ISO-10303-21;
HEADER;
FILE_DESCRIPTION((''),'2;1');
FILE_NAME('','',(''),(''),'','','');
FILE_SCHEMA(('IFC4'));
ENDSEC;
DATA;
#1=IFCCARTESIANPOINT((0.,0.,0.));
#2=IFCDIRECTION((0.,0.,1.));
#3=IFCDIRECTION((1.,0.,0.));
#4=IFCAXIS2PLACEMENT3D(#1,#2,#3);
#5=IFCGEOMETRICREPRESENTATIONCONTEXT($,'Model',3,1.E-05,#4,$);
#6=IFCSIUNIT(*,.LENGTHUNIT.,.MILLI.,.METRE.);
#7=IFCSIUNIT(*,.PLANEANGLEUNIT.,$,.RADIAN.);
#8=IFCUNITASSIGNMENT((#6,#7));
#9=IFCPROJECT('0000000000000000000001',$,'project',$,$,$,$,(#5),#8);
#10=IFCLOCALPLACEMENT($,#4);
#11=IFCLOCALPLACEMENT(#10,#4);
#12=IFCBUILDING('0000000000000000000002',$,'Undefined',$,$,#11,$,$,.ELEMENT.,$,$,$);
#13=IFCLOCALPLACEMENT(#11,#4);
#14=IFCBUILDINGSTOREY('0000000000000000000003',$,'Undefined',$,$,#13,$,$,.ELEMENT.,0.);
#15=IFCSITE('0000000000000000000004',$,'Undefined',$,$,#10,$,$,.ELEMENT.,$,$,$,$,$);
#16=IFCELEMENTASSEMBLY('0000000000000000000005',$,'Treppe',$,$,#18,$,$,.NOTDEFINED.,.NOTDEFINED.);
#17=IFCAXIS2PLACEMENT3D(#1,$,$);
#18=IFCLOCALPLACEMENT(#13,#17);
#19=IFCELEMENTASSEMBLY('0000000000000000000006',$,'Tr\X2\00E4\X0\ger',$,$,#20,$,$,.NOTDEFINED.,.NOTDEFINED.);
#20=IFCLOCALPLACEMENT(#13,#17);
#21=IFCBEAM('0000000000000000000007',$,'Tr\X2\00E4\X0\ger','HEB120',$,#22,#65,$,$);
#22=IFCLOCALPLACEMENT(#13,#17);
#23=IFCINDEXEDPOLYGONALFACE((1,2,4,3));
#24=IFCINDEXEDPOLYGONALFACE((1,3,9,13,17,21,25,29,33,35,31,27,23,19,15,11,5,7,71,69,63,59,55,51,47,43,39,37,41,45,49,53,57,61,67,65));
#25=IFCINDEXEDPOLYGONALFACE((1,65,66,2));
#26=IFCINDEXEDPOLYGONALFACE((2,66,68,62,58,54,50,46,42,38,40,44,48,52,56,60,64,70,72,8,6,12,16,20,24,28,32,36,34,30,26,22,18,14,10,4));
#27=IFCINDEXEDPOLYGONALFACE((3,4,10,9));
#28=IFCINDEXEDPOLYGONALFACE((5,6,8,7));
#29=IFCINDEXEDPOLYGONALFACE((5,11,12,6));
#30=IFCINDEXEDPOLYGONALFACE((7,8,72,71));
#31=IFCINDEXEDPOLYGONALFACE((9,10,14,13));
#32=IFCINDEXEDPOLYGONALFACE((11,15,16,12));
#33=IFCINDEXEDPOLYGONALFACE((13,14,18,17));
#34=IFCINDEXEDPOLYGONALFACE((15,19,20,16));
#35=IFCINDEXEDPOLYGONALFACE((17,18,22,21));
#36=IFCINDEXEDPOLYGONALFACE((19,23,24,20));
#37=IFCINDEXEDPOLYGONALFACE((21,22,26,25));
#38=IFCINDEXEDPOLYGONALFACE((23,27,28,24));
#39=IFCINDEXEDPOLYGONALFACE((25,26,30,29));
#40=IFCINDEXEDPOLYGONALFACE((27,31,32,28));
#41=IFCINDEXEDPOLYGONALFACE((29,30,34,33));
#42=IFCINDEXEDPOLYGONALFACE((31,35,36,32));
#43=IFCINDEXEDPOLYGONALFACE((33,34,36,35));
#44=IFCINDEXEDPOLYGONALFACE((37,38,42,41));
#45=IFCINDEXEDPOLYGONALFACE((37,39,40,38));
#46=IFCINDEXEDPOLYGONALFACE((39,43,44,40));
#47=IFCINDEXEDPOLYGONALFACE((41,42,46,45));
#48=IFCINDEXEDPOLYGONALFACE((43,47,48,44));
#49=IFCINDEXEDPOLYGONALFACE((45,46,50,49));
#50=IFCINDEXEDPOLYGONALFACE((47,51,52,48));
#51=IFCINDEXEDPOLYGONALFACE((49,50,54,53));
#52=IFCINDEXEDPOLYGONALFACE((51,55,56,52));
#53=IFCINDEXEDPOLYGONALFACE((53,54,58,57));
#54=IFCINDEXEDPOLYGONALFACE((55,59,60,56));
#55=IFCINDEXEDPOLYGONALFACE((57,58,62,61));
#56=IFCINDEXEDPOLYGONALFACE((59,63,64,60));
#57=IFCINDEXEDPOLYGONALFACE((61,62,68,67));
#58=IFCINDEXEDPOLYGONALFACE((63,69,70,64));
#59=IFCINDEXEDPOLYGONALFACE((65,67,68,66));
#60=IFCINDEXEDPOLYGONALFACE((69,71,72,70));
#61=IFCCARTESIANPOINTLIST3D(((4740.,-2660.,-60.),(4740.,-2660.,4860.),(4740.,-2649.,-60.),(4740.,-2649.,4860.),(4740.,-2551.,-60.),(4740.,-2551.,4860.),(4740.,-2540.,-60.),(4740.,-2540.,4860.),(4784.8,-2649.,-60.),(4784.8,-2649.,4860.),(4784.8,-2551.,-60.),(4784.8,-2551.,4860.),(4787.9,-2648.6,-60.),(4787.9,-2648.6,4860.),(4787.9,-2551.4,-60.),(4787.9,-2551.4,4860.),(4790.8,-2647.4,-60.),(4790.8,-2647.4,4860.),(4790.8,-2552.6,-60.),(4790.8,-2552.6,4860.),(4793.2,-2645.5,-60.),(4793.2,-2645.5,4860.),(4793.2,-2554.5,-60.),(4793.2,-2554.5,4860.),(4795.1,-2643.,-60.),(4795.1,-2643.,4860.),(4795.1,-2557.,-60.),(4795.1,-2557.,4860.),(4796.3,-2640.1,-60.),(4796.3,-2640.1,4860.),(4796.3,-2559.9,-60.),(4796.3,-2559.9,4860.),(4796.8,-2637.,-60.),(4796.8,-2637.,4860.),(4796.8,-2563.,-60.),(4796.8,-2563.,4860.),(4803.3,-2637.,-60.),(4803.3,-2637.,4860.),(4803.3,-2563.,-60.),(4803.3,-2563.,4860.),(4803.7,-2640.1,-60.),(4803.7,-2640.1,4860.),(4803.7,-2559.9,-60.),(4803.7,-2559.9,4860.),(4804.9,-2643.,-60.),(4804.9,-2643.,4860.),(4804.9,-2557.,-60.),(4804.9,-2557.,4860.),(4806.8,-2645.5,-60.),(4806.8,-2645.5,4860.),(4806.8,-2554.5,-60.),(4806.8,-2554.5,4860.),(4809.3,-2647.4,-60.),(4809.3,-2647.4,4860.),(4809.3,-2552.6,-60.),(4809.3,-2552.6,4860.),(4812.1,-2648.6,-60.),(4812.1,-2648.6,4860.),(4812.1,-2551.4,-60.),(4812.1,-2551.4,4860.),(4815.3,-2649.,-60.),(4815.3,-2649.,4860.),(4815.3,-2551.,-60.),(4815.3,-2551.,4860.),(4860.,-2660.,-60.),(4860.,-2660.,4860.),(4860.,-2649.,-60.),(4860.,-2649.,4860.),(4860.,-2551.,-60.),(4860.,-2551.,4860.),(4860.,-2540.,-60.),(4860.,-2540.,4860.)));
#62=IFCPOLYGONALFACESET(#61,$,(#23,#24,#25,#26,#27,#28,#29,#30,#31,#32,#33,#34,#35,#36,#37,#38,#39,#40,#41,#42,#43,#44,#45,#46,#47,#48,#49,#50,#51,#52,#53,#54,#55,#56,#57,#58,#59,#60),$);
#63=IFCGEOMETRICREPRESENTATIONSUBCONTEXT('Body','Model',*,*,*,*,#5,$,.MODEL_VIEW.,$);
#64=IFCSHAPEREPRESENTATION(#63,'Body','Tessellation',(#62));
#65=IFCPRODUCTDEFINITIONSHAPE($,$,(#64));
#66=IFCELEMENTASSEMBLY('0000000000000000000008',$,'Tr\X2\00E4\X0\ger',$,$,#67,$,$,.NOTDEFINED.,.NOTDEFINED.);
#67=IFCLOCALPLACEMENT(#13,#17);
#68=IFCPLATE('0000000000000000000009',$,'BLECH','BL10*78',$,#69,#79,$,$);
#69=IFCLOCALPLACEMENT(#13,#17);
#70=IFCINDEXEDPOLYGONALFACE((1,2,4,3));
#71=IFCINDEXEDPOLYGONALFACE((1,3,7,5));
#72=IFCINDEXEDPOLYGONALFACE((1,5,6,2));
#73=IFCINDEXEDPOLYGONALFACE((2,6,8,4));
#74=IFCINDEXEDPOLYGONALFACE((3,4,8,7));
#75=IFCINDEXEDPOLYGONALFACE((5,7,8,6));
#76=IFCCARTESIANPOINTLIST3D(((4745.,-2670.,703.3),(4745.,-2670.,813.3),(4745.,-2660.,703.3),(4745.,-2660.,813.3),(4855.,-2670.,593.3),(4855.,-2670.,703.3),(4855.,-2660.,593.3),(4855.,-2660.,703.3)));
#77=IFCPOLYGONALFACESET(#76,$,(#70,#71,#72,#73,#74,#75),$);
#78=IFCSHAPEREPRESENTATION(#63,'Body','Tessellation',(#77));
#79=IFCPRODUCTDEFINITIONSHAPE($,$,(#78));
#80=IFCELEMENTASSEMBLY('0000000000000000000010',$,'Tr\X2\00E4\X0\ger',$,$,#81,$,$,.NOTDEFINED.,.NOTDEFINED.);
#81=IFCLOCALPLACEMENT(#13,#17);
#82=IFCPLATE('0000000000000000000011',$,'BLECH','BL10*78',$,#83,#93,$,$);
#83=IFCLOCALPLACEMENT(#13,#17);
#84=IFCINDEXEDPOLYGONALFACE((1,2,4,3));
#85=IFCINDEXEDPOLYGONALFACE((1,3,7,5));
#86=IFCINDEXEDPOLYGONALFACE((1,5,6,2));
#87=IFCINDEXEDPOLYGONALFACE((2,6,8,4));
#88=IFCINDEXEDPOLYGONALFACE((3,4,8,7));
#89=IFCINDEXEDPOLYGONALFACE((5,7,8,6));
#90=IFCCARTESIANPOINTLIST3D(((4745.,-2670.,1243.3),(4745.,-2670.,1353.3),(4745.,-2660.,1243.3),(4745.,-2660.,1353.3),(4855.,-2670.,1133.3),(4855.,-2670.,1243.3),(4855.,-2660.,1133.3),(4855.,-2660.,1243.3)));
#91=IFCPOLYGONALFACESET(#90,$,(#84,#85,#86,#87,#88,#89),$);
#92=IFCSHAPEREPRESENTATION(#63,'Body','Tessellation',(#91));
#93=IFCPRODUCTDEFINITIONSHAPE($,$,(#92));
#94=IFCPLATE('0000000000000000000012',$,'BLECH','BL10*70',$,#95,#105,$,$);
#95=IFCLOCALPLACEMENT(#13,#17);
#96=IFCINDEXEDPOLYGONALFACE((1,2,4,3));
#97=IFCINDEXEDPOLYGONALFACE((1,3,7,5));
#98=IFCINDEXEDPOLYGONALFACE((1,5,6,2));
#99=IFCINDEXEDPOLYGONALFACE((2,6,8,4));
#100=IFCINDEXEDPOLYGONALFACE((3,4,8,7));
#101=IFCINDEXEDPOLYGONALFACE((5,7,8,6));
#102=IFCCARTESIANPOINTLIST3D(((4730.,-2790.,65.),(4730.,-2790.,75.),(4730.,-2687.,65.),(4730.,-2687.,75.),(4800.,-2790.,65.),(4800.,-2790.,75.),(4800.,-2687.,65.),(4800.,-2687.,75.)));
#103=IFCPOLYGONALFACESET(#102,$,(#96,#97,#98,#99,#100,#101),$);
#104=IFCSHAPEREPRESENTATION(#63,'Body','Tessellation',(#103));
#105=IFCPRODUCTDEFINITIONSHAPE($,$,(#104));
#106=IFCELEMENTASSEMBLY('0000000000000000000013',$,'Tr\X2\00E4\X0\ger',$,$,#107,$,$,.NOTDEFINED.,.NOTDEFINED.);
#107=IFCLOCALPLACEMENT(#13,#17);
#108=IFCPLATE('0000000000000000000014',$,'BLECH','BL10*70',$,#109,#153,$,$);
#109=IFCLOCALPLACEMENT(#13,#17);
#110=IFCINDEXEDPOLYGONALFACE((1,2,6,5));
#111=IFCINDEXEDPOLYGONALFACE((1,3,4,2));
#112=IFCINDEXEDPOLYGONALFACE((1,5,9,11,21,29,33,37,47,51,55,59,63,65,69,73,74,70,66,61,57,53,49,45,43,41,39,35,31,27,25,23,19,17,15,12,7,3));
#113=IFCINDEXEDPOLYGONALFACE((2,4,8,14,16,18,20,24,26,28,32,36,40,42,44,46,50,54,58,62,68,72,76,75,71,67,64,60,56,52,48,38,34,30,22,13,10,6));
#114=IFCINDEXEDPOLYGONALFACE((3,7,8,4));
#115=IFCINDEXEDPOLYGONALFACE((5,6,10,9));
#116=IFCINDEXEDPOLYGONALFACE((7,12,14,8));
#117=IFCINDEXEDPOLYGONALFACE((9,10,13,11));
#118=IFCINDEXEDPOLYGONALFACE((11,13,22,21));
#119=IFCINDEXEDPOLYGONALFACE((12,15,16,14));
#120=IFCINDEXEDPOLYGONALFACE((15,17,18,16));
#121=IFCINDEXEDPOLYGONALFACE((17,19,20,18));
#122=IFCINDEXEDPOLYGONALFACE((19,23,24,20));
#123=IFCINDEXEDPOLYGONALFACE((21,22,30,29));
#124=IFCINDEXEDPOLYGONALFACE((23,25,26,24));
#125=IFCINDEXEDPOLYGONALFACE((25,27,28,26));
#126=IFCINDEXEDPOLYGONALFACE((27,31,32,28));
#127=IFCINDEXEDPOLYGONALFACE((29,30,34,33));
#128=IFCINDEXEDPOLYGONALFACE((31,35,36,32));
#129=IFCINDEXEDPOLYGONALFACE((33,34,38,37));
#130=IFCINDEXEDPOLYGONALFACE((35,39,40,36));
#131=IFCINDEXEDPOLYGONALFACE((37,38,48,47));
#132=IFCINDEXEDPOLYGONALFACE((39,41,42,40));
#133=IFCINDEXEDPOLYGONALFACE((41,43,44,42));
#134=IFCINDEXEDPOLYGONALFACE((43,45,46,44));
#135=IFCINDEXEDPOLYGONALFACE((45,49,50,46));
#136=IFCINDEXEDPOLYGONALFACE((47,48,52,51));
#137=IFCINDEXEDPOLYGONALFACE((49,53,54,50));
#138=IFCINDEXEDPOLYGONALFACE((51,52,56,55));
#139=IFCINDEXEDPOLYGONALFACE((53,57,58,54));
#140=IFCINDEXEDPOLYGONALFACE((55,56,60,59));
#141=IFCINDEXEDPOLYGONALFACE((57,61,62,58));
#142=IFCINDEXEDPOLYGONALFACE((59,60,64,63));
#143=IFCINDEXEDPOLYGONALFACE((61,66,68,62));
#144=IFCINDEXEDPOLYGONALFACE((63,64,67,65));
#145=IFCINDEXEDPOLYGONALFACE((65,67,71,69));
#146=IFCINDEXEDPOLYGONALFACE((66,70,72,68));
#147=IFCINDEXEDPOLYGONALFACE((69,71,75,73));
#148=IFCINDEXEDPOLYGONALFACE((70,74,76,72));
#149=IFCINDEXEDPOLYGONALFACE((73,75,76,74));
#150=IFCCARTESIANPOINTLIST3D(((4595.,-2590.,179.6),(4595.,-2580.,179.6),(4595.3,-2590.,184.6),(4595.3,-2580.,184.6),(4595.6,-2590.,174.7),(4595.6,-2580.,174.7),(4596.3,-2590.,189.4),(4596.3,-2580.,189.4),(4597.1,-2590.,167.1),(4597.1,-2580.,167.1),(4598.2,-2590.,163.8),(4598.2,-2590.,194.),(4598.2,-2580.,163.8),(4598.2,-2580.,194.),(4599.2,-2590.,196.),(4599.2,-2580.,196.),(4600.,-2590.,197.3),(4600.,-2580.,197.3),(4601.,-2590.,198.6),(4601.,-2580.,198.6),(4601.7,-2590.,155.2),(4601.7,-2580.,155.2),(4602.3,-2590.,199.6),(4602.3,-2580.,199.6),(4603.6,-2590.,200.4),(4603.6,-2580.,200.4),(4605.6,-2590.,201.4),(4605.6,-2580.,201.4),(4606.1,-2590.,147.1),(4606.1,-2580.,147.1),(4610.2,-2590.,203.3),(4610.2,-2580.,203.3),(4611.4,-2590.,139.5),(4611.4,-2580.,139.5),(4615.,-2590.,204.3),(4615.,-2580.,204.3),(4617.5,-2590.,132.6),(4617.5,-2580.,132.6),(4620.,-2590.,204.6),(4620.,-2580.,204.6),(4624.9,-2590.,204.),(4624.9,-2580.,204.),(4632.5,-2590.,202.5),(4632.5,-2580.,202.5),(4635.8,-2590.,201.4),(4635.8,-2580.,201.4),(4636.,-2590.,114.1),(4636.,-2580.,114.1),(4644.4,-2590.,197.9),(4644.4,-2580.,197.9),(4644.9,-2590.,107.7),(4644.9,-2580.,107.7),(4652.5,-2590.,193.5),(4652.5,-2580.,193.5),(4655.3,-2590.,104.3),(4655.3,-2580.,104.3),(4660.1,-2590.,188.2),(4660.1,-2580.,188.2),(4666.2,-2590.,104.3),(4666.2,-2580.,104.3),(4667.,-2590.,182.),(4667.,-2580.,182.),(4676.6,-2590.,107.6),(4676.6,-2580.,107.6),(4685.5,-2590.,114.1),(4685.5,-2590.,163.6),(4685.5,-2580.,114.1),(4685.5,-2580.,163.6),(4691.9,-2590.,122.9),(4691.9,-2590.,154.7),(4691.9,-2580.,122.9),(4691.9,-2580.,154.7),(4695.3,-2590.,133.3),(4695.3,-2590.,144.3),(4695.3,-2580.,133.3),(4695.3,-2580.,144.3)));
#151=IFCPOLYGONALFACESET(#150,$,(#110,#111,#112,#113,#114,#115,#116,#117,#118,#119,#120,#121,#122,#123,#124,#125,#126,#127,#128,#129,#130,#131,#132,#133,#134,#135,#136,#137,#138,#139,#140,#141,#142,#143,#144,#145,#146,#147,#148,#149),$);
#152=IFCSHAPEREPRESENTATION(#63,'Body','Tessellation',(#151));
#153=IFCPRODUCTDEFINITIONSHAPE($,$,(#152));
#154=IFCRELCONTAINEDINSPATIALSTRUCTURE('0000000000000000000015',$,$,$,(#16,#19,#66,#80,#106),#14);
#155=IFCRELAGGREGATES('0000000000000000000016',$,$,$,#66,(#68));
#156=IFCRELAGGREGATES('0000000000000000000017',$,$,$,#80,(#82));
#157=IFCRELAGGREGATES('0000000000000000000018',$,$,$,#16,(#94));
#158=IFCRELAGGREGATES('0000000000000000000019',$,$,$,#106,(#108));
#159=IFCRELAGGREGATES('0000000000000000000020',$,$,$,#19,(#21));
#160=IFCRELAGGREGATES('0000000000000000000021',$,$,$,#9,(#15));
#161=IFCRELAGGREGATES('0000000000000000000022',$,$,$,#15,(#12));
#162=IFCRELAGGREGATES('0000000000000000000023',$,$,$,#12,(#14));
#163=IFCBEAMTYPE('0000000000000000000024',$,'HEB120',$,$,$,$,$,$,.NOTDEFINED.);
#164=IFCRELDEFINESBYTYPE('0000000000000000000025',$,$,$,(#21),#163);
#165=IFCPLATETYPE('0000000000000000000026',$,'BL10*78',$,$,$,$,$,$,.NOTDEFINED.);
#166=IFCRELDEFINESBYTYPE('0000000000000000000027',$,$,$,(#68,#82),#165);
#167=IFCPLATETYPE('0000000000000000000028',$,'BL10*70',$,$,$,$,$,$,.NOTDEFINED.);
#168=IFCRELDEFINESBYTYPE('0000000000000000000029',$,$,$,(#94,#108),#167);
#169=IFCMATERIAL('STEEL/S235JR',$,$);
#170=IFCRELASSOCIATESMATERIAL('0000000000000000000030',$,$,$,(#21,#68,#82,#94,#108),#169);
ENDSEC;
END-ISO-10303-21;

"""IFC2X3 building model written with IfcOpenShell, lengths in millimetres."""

from ifc_helpers import new_model, si_unit, frame, origin_with_axes, origin_2d_with_axis, place, context, subcontext, project, spatial, polyline, i_section, outline, extrude, material, type_object, element, aggregate, save


model = new_model("IFC2X3")

# Units and contexts
model_context = context("Model", 3, precision=1e-05, world=origin_with_axes())
body_context = subcontext(model_context, "Body", "Model", "MODEL_VIEW")
ifc_project = project(units=[si_unit("LENGTHUNIT", "METRE", prefix="MILLI"), si_unit("PLANEANGLEUNIT", "RADIAN")], contexts=[model_context])

# Site, building, storey
site_placement = place(None, origin_with_axes())
site = spatial("IfcSite", under=ifc_project, at=site_placement, Name="Undefined", CompositionType="ELEMENT")
building_placement = place(site_placement, origin_with_axes())
building = spatial("IfcBuilding", under=site, at=building_placement, Name="Undefined", CompositionType="ELEMENT")
storey_placement = place(building_placement, origin_with_axes())
storey = spatial("IfcBuildingStorey", under=building, at=storey_placement, Name="Undefined", CompositionType="ELEMENT", Elevation=0.0)

# Shared definitions
ifc_material_1 = material(Name="STEEL/S235JR")

# Element assembly
assembly_1_placement = place(storey_placement, origin_with_axes())
assembly_1 = element("IfcElementAssembly", 1, at=assembly_1_placement, inside=storey, Name="Treppe", AssemblyPlace="NOTDEFINED", PredefinedType="NOTDEFINED")

# Element assembly
assembly_2_placement = place(storey_placement, origin_with_axes())
assembly_2 = element("IfcElementAssembly", 2, at=assembly_2_placement, inside=storey, Name="Träger", AssemblyPlace="NOTDEFINED", PredefinedType="NOTDEFINED")
beam_type_1 = type_object("IfcBeamType", Name="HEB120", PredefinedType="NOTDEFINED")

# Beam
beam_1_placement = place(assembly_2_placement, frame((4800.0, -2600.0, -60.0), z_axis=(0.0, 1.0, 0.0), x_axis=(0.0, 0.0, 1.0)))
beam_1 = element("IfcBeam", 3, at=beam_1_placement, type_object=beam_type_1, material=ifc_material_1, Name="Träger", Description="HEB120", context=body_context, shape_type="SweptSolid", body=[
    extrude(i_section(OverallWidth=120.0, OverallDepth=120.0, WebThickness=6.5, FlangeThickness=11.0, FilletRadius=12.0, at=origin_2d_with_axis()), frame((4920.0, 0.0, 0.0), z_axis=(-1.0, 0.0, 0.0), x_axis=(0.0, -1.0, 0.0)), (0.0, 0.0, 1.0), 4920.0),
])

# Element assemblies, plates
assembly_3_placement = place(storey_placement, origin_with_axes())
assembly_3 = element("IfcElementAssembly", 4, at=assembly_3_placement, inside=storey, Name="Träger", AssemblyPlace="NOTDEFINED", PredefinedType="NOTDEFINED")
plate_type_1 = type_object("IfcPlateType", Name="BL10*78", PredefinedType="NOTDEFINED")
plate_1_placement = place(assembly_3_placement, frame((4855.0, -2665.0, 703.3), z_axis=(0.0, -1.0, 0.0), x_axis=(-0.707102, 0.0, 0.707111)))
plate_1 = element("IfcPlate", 5, at=plate_1_placement, type_object=plate_type_1, material=ifc_material_1, Name="BLECH", Description="BL10*78", context=body_context, shape_type="SweptSolid", body=[
    extrude(outline(polyline([(0.0, 0.0), (155.6, 0.0), (77.8, 77.8), (-77.8, 77.8), (0.0, 0.0)])), frame((0.0, 0.0, -5.0), z_axis=(0.0, 0.0, 1.0), x_axis=(1.0, 0.0, 0.0)), (0.0, 0.0, 1.0), 10.0),
])
aggregate(assembly_3, [plate_1])
assembly_4_placement = place(storey_placement, origin_with_axes())
assembly_4 = element("IfcElementAssembly", 6, at=assembly_4_placement, inside=storey, Name="Träger", AssemblyPlace="NOTDEFINED", PredefinedType="NOTDEFINED")
plate_2_placement = place(assembly_4_placement, frame((4855.0, -2665.0, 1243.3), z_axis=(0.0, -1.0, 0.0), x_axis=(-0.707102, 0.0, 0.707111)))
plate_2 = element("IfcPlate", 7, at=plate_2_placement, type_object=plate_type_1, material=ifc_material_1, Name="BLECH", Description="BL10*78", context=body_context, shape_type="SweptSolid", body=[
    extrude(outline(polyline([(0.0, 0.0), (155.6, 0.0), (77.8, 77.8), (-77.8, 77.8), (0.0, 0.0)])), frame((0.0, 0.0, -5.0), z_axis=(0.0, 0.0, 1.0), x_axis=(1.0, 0.0, 0.0)), (0.0, 0.0, 1.0), 10.0),
])
aggregate(assembly_4, [plate_2])

# Plate
plate_type_2 = type_object("IfcPlateType", Name="BL10*70", PredefinedType="NOTDEFINED")
plate_3_placement = place(assembly_1_placement, frame((4800.0, -2687.0, 70.0), z_axis=(0.0, 0.0, -1.0), x_axis=(0.000009, -1.0, 0.0)))
plate_3 = element("IfcPlate", 8, at=plate_3_placement, type_object=plate_type_2, material=ifc_material_1, Name="BLECH", Description="BL10*70", context=body_context, shape_type="SweptSolid", body=[
    extrude(outline(polyline([(0.0, 0.0), (103.0, 0.0), (103.0, 70.0), (0.0, 70.0), (0.0, 0.0)])), frame((0.0, 0.0, -5.0), z_axis=(0.0, 0.0, 1.0), x_axis=(1.0, 0.0, 0.0)), (0.0, 0.0, 1.0), 10.0),
])
aggregate(assembly_1, [plate_3])

# Element assembly, plate
assembly_5_placement = place(storey_placement, origin_with_axes())
assembly_5 = element("IfcElementAssembly", 9, at=assembly_5_placement, inside=storey, Name="Träger", AssemblyPlace="NOTDEFINED", PredefinedType="NOTDEFINED")
plate_4_placement = place(assembly_5_placement, frame((4604.2, -2585.0, 145.9), z_axis=(0.0, 1.0, 0.0), x_axis=(-0.316089, 0.0, 0.94873)))
plate_4 = element("IfcPlate", 10, at=plate_4_placement, type_object=plate_type_2, material=ifc_material_1, Name="BLECH", Description="BL10*70", context=body_context, shape_type="SweptSolid", body=[
    extrude(outline(polyline([(-16.9, 8.4), (-8.4, 4.8), (0.5, 2.1), (9.6, 0.5), (18.9, 0.0), (22.4, 0.0), (30.0, 1.0), (34.9, 2.0), (39.5, 3.8), (43.7, 6.3), (47.5, 9.5), (49.1, 11.1), (50.1, 12.3), (50.9, 13.7), (51.5, 15.1), (51.9, 16.7), (52.2, 18.9), (52.5, 23.8), (52.0, 28.7), (50.6, 33.5), (48.6, 38.0), (44.7, 44.7), (42.6, 47.5), (36.6, 54.6), (29.9, 60.9), (22.4, 66.4), (14.4, 71.0), (-9.0, 82.7), (-19.4, 86.0), (-30.3, 86.0), (-40.7, 82.5), (-49.5, 76.0), (-55.9, 67.1), (-55.9, 67.1), (-59.2, 56.6), (-59.1, 45.7), (-55.7, 35.3), (-49.2, 26.5), (-40.3, 20.1), (-16.9, 8.4)])), frame((0.0, 0.0, -5.0), z_axis=(0.0, 0.0, 1.0), x_axis=(1.0, 0.0, 0.0)), (0.0, 0.0, 1.0), 10.0),
])

aggregate(assembly_5, [plate_4])

aggregate(assembly_2, [beam_1])

save(model, "model.ifc")
